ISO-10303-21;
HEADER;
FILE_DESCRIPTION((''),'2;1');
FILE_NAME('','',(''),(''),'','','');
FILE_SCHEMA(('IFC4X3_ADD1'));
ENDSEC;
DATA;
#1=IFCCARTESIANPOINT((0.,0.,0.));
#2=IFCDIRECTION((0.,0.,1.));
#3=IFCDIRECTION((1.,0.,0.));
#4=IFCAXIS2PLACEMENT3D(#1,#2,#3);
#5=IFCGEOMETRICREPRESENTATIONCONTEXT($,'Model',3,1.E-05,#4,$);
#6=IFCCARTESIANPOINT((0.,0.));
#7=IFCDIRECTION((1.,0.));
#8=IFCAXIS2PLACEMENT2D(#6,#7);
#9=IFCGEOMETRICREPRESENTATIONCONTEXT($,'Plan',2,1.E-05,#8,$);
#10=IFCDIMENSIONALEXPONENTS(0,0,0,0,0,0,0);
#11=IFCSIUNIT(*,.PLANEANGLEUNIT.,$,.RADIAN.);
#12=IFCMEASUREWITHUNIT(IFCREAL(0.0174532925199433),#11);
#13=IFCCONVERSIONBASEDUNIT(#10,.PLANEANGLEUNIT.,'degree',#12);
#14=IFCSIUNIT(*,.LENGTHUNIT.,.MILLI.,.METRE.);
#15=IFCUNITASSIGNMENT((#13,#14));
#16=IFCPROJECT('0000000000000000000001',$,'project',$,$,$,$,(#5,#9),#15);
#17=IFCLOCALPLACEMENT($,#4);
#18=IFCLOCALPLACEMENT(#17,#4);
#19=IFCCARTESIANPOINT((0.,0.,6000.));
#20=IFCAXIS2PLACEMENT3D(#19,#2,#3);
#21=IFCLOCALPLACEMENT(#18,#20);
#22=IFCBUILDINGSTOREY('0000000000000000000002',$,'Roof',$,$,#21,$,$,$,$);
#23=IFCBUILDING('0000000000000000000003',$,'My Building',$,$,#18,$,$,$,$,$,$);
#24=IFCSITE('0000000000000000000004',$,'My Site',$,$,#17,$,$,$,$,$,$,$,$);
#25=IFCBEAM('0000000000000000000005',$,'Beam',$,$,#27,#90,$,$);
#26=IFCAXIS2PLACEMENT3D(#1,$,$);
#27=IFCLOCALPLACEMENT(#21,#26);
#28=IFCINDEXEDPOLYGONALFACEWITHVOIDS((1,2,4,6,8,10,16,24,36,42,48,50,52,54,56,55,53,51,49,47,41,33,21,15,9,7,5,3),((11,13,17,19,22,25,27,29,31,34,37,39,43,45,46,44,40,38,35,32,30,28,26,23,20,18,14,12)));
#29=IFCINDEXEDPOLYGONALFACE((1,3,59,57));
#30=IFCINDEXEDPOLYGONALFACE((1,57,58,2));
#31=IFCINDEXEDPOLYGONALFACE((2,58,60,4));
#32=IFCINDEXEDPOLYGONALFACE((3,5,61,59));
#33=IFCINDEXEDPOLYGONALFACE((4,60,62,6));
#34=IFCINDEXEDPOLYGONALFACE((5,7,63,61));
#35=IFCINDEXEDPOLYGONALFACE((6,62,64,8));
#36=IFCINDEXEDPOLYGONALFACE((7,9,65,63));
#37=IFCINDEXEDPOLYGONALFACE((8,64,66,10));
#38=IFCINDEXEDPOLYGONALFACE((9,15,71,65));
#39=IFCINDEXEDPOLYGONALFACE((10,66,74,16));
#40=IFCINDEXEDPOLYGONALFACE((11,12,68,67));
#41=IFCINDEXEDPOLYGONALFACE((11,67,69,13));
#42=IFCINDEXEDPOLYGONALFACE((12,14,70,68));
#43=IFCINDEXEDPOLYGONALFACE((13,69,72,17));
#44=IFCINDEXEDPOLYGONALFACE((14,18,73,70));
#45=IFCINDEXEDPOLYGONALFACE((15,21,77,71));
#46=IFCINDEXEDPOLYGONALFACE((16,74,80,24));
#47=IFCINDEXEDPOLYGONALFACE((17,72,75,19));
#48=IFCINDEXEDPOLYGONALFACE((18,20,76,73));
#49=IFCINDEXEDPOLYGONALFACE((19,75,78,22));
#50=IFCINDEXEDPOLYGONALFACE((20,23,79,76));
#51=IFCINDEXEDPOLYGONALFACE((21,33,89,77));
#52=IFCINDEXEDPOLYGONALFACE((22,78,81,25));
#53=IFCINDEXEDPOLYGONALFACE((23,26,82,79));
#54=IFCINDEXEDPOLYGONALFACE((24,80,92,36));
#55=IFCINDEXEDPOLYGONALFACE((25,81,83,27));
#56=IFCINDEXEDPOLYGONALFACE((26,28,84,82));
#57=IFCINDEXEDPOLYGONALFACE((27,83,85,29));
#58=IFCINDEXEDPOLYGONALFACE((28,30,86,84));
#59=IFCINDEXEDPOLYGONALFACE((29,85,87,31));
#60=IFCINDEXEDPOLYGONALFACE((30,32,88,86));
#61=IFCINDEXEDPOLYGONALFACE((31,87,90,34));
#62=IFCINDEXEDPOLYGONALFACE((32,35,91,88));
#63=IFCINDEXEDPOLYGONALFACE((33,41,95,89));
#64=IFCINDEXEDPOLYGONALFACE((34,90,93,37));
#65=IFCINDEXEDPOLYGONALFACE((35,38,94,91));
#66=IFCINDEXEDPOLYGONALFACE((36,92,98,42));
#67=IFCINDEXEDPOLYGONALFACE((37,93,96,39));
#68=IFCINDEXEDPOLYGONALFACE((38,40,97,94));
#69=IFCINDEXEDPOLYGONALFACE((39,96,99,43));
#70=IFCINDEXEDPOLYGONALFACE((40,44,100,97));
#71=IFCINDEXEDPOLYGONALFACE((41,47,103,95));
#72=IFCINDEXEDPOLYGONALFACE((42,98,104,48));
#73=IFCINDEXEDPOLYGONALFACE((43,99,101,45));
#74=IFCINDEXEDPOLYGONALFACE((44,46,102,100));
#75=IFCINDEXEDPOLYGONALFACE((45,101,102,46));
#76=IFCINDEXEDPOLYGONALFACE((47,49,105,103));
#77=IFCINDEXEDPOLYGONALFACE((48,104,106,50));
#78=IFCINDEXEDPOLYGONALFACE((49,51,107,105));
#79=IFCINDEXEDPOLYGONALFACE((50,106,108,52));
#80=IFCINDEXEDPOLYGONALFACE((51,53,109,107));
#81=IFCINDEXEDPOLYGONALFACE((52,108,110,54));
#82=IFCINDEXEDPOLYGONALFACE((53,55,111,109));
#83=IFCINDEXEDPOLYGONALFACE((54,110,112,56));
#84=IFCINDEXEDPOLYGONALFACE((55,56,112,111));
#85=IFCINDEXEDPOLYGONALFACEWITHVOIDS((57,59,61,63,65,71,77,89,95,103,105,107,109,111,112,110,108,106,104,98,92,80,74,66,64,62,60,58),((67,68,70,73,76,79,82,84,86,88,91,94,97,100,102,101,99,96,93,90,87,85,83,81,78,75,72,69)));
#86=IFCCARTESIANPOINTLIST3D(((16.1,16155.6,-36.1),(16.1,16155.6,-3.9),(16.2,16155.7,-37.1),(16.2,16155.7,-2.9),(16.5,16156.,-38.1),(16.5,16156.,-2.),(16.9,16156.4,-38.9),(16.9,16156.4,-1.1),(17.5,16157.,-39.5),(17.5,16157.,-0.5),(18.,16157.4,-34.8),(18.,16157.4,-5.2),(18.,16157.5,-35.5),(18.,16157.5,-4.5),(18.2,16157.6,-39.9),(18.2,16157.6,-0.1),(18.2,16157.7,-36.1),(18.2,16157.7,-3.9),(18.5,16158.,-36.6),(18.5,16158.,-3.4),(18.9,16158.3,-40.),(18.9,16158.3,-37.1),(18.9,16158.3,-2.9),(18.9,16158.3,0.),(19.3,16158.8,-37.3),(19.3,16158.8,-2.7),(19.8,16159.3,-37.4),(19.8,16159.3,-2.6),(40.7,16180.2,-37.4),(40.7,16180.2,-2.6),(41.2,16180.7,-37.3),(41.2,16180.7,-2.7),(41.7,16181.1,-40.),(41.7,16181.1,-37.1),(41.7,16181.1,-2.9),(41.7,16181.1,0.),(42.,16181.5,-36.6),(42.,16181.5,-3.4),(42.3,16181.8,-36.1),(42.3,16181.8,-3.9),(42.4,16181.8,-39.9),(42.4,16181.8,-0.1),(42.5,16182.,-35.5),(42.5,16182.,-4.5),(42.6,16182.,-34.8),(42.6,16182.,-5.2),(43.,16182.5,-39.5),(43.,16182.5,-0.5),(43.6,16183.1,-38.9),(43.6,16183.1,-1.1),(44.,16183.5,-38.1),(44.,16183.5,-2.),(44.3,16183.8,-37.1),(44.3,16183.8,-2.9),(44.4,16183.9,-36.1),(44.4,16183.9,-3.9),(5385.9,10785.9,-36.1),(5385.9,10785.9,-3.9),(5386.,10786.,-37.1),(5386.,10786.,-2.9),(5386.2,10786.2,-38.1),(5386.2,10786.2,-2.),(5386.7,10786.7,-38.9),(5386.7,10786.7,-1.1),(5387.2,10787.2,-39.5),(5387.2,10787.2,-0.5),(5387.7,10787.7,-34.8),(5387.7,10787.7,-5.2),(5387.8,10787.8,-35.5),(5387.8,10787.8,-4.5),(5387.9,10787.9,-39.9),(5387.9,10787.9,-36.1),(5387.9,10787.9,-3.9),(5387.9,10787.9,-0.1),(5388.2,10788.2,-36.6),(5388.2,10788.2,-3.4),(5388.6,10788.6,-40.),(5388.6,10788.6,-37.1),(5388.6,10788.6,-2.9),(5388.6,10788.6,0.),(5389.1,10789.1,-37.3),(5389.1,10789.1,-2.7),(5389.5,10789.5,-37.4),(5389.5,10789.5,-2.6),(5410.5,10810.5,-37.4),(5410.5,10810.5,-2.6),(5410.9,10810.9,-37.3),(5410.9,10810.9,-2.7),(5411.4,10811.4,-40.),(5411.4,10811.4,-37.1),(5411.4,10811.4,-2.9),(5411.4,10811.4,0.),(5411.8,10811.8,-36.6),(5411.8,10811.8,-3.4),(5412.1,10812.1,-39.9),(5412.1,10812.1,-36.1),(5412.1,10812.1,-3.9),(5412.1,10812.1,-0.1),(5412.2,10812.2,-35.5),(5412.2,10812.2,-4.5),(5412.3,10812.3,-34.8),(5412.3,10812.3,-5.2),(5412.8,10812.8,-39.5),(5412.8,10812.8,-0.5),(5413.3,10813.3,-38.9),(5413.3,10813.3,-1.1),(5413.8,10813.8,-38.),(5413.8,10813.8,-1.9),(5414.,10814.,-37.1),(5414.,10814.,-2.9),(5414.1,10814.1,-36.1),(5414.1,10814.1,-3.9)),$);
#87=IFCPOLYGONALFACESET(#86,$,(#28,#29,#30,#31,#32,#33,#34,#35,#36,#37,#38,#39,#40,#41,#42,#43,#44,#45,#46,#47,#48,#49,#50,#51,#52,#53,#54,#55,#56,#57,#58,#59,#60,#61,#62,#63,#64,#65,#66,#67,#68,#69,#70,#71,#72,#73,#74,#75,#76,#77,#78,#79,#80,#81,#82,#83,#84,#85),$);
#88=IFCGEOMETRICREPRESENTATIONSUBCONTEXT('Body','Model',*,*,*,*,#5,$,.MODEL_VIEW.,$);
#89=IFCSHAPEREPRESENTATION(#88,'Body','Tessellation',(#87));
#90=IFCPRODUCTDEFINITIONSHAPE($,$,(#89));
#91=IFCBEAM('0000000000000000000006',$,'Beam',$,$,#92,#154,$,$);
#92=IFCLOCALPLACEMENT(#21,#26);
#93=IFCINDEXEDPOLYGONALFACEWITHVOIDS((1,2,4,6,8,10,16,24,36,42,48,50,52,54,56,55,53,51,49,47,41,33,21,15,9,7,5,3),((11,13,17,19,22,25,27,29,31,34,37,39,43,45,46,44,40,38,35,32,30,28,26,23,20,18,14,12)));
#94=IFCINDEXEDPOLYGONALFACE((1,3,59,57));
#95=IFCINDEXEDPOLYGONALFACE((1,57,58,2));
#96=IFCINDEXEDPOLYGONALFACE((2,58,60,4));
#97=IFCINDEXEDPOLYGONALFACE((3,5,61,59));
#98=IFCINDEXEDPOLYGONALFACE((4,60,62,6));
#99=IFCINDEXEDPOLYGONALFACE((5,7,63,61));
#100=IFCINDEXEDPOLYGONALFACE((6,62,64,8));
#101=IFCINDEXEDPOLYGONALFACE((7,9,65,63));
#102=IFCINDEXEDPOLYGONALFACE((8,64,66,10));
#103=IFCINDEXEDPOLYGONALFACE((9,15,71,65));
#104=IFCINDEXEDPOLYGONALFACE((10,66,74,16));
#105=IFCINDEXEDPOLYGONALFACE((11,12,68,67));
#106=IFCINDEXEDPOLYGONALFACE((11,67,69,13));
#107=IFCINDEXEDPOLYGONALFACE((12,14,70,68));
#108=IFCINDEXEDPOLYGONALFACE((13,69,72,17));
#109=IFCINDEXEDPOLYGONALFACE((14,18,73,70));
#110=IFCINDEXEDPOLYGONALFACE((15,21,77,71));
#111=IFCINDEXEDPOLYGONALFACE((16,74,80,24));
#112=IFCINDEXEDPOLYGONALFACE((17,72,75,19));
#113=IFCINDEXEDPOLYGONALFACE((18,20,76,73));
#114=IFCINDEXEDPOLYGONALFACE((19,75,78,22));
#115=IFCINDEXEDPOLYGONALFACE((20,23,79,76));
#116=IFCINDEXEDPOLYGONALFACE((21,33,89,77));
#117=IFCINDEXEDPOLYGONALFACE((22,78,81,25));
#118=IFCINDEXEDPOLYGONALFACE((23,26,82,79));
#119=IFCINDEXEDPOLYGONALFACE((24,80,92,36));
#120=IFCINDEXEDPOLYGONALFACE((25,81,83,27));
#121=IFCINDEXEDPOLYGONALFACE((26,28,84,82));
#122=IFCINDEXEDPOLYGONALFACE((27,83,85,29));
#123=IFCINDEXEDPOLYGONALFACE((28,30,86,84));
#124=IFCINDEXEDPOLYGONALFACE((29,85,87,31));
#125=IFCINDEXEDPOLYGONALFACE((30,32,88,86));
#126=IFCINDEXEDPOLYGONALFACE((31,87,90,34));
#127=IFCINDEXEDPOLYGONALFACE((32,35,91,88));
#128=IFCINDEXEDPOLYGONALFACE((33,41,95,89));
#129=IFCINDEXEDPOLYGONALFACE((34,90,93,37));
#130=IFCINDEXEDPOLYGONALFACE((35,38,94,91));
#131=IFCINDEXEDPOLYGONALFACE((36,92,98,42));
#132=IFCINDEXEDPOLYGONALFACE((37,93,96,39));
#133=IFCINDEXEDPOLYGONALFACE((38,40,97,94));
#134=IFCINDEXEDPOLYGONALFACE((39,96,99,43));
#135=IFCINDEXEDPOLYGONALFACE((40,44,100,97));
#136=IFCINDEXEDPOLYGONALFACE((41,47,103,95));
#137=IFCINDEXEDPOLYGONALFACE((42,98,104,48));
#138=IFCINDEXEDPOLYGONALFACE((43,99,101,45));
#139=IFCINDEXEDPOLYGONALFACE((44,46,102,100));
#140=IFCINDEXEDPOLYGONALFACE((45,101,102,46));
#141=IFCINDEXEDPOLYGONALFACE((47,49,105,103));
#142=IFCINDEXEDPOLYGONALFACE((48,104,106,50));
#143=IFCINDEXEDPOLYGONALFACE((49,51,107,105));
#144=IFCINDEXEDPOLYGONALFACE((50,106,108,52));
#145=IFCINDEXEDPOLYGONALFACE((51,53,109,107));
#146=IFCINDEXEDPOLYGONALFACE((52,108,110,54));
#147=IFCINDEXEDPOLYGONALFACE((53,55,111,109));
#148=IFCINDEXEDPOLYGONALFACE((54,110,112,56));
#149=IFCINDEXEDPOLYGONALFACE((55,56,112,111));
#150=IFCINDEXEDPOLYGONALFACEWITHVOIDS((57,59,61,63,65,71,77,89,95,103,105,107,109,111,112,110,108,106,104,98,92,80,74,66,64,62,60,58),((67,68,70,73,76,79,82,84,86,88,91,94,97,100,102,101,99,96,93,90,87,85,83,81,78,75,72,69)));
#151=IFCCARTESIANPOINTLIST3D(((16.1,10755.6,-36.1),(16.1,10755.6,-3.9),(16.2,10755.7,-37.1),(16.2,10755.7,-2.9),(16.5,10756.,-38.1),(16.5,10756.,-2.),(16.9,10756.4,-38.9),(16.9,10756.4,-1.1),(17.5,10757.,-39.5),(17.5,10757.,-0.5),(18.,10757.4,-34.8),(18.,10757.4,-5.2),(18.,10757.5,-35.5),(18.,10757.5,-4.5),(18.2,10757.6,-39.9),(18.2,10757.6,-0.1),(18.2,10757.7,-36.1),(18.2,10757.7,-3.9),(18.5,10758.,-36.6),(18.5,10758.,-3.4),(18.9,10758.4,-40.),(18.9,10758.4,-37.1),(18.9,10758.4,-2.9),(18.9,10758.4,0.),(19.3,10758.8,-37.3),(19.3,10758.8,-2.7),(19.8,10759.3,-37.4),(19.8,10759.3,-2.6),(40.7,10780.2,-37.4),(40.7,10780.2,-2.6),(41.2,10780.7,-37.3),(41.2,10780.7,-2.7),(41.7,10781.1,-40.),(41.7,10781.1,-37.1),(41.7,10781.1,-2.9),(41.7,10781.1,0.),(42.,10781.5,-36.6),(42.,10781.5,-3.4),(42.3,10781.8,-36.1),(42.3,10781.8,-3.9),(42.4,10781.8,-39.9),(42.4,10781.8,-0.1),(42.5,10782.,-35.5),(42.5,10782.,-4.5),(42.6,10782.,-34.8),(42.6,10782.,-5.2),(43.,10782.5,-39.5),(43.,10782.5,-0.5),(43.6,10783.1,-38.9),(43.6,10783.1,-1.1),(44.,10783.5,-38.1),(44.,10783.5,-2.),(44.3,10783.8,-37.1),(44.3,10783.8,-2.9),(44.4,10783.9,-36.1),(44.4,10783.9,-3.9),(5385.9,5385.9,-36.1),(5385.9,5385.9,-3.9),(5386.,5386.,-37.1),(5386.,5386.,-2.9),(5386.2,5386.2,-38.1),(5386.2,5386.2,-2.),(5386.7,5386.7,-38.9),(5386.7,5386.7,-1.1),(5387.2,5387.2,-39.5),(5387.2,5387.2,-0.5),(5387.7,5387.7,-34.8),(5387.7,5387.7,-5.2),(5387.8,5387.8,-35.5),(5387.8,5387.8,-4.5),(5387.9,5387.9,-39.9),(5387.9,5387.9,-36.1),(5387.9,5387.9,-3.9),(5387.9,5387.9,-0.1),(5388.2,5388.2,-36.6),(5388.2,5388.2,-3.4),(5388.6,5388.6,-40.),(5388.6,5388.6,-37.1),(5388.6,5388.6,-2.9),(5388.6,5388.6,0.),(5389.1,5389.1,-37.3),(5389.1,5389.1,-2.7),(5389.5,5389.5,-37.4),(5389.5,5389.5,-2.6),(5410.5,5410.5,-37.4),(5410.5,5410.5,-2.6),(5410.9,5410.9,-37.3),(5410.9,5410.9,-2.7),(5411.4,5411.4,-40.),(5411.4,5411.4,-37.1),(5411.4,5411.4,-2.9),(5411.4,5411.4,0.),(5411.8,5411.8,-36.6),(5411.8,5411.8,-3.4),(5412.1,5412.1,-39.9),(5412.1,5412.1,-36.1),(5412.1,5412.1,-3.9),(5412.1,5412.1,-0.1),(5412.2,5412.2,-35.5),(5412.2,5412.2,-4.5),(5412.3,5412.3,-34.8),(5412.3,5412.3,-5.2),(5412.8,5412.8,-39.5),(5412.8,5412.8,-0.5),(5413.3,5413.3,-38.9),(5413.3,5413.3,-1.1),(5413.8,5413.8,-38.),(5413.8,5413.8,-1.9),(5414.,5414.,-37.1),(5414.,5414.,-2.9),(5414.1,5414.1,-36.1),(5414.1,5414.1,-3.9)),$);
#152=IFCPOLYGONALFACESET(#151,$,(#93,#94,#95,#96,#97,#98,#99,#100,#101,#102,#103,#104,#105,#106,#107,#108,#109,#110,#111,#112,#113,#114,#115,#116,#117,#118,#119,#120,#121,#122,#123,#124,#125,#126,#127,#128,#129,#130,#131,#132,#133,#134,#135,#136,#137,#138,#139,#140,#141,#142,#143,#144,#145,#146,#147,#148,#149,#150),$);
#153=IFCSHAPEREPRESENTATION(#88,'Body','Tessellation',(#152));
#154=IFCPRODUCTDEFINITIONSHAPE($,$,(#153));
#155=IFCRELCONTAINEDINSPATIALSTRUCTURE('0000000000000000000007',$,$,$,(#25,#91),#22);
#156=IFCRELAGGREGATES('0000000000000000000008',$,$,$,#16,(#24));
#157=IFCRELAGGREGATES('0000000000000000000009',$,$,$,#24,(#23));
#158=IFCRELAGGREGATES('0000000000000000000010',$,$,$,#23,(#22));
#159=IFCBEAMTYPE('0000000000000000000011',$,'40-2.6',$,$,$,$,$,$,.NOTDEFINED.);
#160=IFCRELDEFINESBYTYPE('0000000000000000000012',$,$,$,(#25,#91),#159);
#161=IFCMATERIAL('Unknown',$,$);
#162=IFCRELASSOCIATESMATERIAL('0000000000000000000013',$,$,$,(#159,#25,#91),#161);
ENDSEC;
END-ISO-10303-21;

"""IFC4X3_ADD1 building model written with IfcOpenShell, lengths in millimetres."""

from ifc_helpers import new_model, entity, si_unit, converted_unit, frame, origin_with_axes, origin_2d_with_axis, place, context, subcontext, project, spatial, hollow_rectangle, extrude, material, material_profile, profile_set, profile_usage, type_object, element, save


model = new_model("IFC4X3_ADD1")

# Units and contexts
model_context = context("Model", 3, precision=1e-05, world=origin_with_axes())
plan_context = context("Plan", 2, precision=1e-05, world=origin_2d_with_axis())
body_context = subcontext(model_context, "Body", "Model", "MODEL_VIEW")
ifc_project = project(units=[converted_unit("PLANEANGLEUNIT", "degree", entity("IfcReal", 0.0174532925199433), si_unit("PLANEANGLEUNIT", "RADIAN"), dimensions=[0, 0, 0, 0, 0, 0, 0]), si_unit("LENGTHUNIT", "METRE", prefix="MILLI")], contexts=[model_context, plan_context])

# Site, building, storey
site_placement = place(None, origin_with_axes())
site = spatial("IfcSite", under=ifc_project, at=site_placement, Name="My Site")
building_placement = place(site_placement, origin_with_axes())
building = spatial("IfcBuilding", under=site, at=building_placement, Name="My Building")
storey_placement = place(building_placement, frame((0.0, 0.0, 6000.0), z_axis=(0.0, 0.0, 1.0), x_axis=(1.0, 0.0, 0.0)))
storey = spatial("IfcBuildingStorey", under=building, at=storey_placement, Name="Roof")

# Beams
ifc_material = material(Name="Unknown")
ifc_material_profile_1 = material_profile(ifc_material, hollow_rectangle(XDim=40.0, YDim=40.0, WallThickness=2.6, InnerFilletRadius=2.6, OuterFilletRadius=3.9))
ifc_profile_set_1 = profile_set([ifc_material_profile_1])
ifc_profile_usage_1 = profile_usage(ifc_profile_set_1, cardinal=8)
beam_type_1 = type_object("IfcBeamType", Name="40-2.6", PredefinedType="NOTDEFINED", material=ifc_profile_set_1)
beam_1_placement = place(storey_placement, frame((5400.0, 10800.0, 0.0), z_axis=(-0.707107, 0.707107, 0.0), x_axis=(-0.707107, -0.707107, 0.0)))
element("IfcBeam", 1, at=beam_1_placement, inside=storey, type_object=beam_type_1, material=ifc_profile_usage_1, Name="Beam", context=body_context, shape_type="SweptSolid", body=[
    extrude(hollow_rectangle(XDim=40.0, YDim=40.0, WallThickness=2.6, InnerFilletRadius=2.6, OuterFilletRadius=3.9), frame((0.0, -20.0, 0.0), z_axis=(0.0, 0.0, 1.0), x_axis=(1.0, 0.0, 0.0)), (0.0, 0.0, 1.0), 7594.0),
])
ifc_profile_usage_2 = profile_usage(ifc_profile_set_1, cardinal=8)
beam_2_placement = place(storey_placement, frame((5400.0, 5400.0, 0.0), z_axis=(-0.707107, 0.707107, 0.0), x_axis=(-0.707107, -0.707107, 0.0)))
element("IfcBeam", 2, at=beam_2_placement, inside=storey, type_object=beam_type_1, material=ifc_profile_usage_2, Name="Beam", context=body_context, shape_type="SweptSolid", body=[
    extrude(hollow_rectangle(XDim=40.0, YDim=40.0, WallThickness=2.6, InnerFilletRadius=2.6, OuterFilletRadius=3.9), frame((0.0, -20.0, 0.0), z_axis=(0.0, 0.0, 1.0), x_axis=(1.0, 0.0, 0.0)), (0.0, 0.0, 1.0), 7594.0),
])

save(model, "model.ifc")
